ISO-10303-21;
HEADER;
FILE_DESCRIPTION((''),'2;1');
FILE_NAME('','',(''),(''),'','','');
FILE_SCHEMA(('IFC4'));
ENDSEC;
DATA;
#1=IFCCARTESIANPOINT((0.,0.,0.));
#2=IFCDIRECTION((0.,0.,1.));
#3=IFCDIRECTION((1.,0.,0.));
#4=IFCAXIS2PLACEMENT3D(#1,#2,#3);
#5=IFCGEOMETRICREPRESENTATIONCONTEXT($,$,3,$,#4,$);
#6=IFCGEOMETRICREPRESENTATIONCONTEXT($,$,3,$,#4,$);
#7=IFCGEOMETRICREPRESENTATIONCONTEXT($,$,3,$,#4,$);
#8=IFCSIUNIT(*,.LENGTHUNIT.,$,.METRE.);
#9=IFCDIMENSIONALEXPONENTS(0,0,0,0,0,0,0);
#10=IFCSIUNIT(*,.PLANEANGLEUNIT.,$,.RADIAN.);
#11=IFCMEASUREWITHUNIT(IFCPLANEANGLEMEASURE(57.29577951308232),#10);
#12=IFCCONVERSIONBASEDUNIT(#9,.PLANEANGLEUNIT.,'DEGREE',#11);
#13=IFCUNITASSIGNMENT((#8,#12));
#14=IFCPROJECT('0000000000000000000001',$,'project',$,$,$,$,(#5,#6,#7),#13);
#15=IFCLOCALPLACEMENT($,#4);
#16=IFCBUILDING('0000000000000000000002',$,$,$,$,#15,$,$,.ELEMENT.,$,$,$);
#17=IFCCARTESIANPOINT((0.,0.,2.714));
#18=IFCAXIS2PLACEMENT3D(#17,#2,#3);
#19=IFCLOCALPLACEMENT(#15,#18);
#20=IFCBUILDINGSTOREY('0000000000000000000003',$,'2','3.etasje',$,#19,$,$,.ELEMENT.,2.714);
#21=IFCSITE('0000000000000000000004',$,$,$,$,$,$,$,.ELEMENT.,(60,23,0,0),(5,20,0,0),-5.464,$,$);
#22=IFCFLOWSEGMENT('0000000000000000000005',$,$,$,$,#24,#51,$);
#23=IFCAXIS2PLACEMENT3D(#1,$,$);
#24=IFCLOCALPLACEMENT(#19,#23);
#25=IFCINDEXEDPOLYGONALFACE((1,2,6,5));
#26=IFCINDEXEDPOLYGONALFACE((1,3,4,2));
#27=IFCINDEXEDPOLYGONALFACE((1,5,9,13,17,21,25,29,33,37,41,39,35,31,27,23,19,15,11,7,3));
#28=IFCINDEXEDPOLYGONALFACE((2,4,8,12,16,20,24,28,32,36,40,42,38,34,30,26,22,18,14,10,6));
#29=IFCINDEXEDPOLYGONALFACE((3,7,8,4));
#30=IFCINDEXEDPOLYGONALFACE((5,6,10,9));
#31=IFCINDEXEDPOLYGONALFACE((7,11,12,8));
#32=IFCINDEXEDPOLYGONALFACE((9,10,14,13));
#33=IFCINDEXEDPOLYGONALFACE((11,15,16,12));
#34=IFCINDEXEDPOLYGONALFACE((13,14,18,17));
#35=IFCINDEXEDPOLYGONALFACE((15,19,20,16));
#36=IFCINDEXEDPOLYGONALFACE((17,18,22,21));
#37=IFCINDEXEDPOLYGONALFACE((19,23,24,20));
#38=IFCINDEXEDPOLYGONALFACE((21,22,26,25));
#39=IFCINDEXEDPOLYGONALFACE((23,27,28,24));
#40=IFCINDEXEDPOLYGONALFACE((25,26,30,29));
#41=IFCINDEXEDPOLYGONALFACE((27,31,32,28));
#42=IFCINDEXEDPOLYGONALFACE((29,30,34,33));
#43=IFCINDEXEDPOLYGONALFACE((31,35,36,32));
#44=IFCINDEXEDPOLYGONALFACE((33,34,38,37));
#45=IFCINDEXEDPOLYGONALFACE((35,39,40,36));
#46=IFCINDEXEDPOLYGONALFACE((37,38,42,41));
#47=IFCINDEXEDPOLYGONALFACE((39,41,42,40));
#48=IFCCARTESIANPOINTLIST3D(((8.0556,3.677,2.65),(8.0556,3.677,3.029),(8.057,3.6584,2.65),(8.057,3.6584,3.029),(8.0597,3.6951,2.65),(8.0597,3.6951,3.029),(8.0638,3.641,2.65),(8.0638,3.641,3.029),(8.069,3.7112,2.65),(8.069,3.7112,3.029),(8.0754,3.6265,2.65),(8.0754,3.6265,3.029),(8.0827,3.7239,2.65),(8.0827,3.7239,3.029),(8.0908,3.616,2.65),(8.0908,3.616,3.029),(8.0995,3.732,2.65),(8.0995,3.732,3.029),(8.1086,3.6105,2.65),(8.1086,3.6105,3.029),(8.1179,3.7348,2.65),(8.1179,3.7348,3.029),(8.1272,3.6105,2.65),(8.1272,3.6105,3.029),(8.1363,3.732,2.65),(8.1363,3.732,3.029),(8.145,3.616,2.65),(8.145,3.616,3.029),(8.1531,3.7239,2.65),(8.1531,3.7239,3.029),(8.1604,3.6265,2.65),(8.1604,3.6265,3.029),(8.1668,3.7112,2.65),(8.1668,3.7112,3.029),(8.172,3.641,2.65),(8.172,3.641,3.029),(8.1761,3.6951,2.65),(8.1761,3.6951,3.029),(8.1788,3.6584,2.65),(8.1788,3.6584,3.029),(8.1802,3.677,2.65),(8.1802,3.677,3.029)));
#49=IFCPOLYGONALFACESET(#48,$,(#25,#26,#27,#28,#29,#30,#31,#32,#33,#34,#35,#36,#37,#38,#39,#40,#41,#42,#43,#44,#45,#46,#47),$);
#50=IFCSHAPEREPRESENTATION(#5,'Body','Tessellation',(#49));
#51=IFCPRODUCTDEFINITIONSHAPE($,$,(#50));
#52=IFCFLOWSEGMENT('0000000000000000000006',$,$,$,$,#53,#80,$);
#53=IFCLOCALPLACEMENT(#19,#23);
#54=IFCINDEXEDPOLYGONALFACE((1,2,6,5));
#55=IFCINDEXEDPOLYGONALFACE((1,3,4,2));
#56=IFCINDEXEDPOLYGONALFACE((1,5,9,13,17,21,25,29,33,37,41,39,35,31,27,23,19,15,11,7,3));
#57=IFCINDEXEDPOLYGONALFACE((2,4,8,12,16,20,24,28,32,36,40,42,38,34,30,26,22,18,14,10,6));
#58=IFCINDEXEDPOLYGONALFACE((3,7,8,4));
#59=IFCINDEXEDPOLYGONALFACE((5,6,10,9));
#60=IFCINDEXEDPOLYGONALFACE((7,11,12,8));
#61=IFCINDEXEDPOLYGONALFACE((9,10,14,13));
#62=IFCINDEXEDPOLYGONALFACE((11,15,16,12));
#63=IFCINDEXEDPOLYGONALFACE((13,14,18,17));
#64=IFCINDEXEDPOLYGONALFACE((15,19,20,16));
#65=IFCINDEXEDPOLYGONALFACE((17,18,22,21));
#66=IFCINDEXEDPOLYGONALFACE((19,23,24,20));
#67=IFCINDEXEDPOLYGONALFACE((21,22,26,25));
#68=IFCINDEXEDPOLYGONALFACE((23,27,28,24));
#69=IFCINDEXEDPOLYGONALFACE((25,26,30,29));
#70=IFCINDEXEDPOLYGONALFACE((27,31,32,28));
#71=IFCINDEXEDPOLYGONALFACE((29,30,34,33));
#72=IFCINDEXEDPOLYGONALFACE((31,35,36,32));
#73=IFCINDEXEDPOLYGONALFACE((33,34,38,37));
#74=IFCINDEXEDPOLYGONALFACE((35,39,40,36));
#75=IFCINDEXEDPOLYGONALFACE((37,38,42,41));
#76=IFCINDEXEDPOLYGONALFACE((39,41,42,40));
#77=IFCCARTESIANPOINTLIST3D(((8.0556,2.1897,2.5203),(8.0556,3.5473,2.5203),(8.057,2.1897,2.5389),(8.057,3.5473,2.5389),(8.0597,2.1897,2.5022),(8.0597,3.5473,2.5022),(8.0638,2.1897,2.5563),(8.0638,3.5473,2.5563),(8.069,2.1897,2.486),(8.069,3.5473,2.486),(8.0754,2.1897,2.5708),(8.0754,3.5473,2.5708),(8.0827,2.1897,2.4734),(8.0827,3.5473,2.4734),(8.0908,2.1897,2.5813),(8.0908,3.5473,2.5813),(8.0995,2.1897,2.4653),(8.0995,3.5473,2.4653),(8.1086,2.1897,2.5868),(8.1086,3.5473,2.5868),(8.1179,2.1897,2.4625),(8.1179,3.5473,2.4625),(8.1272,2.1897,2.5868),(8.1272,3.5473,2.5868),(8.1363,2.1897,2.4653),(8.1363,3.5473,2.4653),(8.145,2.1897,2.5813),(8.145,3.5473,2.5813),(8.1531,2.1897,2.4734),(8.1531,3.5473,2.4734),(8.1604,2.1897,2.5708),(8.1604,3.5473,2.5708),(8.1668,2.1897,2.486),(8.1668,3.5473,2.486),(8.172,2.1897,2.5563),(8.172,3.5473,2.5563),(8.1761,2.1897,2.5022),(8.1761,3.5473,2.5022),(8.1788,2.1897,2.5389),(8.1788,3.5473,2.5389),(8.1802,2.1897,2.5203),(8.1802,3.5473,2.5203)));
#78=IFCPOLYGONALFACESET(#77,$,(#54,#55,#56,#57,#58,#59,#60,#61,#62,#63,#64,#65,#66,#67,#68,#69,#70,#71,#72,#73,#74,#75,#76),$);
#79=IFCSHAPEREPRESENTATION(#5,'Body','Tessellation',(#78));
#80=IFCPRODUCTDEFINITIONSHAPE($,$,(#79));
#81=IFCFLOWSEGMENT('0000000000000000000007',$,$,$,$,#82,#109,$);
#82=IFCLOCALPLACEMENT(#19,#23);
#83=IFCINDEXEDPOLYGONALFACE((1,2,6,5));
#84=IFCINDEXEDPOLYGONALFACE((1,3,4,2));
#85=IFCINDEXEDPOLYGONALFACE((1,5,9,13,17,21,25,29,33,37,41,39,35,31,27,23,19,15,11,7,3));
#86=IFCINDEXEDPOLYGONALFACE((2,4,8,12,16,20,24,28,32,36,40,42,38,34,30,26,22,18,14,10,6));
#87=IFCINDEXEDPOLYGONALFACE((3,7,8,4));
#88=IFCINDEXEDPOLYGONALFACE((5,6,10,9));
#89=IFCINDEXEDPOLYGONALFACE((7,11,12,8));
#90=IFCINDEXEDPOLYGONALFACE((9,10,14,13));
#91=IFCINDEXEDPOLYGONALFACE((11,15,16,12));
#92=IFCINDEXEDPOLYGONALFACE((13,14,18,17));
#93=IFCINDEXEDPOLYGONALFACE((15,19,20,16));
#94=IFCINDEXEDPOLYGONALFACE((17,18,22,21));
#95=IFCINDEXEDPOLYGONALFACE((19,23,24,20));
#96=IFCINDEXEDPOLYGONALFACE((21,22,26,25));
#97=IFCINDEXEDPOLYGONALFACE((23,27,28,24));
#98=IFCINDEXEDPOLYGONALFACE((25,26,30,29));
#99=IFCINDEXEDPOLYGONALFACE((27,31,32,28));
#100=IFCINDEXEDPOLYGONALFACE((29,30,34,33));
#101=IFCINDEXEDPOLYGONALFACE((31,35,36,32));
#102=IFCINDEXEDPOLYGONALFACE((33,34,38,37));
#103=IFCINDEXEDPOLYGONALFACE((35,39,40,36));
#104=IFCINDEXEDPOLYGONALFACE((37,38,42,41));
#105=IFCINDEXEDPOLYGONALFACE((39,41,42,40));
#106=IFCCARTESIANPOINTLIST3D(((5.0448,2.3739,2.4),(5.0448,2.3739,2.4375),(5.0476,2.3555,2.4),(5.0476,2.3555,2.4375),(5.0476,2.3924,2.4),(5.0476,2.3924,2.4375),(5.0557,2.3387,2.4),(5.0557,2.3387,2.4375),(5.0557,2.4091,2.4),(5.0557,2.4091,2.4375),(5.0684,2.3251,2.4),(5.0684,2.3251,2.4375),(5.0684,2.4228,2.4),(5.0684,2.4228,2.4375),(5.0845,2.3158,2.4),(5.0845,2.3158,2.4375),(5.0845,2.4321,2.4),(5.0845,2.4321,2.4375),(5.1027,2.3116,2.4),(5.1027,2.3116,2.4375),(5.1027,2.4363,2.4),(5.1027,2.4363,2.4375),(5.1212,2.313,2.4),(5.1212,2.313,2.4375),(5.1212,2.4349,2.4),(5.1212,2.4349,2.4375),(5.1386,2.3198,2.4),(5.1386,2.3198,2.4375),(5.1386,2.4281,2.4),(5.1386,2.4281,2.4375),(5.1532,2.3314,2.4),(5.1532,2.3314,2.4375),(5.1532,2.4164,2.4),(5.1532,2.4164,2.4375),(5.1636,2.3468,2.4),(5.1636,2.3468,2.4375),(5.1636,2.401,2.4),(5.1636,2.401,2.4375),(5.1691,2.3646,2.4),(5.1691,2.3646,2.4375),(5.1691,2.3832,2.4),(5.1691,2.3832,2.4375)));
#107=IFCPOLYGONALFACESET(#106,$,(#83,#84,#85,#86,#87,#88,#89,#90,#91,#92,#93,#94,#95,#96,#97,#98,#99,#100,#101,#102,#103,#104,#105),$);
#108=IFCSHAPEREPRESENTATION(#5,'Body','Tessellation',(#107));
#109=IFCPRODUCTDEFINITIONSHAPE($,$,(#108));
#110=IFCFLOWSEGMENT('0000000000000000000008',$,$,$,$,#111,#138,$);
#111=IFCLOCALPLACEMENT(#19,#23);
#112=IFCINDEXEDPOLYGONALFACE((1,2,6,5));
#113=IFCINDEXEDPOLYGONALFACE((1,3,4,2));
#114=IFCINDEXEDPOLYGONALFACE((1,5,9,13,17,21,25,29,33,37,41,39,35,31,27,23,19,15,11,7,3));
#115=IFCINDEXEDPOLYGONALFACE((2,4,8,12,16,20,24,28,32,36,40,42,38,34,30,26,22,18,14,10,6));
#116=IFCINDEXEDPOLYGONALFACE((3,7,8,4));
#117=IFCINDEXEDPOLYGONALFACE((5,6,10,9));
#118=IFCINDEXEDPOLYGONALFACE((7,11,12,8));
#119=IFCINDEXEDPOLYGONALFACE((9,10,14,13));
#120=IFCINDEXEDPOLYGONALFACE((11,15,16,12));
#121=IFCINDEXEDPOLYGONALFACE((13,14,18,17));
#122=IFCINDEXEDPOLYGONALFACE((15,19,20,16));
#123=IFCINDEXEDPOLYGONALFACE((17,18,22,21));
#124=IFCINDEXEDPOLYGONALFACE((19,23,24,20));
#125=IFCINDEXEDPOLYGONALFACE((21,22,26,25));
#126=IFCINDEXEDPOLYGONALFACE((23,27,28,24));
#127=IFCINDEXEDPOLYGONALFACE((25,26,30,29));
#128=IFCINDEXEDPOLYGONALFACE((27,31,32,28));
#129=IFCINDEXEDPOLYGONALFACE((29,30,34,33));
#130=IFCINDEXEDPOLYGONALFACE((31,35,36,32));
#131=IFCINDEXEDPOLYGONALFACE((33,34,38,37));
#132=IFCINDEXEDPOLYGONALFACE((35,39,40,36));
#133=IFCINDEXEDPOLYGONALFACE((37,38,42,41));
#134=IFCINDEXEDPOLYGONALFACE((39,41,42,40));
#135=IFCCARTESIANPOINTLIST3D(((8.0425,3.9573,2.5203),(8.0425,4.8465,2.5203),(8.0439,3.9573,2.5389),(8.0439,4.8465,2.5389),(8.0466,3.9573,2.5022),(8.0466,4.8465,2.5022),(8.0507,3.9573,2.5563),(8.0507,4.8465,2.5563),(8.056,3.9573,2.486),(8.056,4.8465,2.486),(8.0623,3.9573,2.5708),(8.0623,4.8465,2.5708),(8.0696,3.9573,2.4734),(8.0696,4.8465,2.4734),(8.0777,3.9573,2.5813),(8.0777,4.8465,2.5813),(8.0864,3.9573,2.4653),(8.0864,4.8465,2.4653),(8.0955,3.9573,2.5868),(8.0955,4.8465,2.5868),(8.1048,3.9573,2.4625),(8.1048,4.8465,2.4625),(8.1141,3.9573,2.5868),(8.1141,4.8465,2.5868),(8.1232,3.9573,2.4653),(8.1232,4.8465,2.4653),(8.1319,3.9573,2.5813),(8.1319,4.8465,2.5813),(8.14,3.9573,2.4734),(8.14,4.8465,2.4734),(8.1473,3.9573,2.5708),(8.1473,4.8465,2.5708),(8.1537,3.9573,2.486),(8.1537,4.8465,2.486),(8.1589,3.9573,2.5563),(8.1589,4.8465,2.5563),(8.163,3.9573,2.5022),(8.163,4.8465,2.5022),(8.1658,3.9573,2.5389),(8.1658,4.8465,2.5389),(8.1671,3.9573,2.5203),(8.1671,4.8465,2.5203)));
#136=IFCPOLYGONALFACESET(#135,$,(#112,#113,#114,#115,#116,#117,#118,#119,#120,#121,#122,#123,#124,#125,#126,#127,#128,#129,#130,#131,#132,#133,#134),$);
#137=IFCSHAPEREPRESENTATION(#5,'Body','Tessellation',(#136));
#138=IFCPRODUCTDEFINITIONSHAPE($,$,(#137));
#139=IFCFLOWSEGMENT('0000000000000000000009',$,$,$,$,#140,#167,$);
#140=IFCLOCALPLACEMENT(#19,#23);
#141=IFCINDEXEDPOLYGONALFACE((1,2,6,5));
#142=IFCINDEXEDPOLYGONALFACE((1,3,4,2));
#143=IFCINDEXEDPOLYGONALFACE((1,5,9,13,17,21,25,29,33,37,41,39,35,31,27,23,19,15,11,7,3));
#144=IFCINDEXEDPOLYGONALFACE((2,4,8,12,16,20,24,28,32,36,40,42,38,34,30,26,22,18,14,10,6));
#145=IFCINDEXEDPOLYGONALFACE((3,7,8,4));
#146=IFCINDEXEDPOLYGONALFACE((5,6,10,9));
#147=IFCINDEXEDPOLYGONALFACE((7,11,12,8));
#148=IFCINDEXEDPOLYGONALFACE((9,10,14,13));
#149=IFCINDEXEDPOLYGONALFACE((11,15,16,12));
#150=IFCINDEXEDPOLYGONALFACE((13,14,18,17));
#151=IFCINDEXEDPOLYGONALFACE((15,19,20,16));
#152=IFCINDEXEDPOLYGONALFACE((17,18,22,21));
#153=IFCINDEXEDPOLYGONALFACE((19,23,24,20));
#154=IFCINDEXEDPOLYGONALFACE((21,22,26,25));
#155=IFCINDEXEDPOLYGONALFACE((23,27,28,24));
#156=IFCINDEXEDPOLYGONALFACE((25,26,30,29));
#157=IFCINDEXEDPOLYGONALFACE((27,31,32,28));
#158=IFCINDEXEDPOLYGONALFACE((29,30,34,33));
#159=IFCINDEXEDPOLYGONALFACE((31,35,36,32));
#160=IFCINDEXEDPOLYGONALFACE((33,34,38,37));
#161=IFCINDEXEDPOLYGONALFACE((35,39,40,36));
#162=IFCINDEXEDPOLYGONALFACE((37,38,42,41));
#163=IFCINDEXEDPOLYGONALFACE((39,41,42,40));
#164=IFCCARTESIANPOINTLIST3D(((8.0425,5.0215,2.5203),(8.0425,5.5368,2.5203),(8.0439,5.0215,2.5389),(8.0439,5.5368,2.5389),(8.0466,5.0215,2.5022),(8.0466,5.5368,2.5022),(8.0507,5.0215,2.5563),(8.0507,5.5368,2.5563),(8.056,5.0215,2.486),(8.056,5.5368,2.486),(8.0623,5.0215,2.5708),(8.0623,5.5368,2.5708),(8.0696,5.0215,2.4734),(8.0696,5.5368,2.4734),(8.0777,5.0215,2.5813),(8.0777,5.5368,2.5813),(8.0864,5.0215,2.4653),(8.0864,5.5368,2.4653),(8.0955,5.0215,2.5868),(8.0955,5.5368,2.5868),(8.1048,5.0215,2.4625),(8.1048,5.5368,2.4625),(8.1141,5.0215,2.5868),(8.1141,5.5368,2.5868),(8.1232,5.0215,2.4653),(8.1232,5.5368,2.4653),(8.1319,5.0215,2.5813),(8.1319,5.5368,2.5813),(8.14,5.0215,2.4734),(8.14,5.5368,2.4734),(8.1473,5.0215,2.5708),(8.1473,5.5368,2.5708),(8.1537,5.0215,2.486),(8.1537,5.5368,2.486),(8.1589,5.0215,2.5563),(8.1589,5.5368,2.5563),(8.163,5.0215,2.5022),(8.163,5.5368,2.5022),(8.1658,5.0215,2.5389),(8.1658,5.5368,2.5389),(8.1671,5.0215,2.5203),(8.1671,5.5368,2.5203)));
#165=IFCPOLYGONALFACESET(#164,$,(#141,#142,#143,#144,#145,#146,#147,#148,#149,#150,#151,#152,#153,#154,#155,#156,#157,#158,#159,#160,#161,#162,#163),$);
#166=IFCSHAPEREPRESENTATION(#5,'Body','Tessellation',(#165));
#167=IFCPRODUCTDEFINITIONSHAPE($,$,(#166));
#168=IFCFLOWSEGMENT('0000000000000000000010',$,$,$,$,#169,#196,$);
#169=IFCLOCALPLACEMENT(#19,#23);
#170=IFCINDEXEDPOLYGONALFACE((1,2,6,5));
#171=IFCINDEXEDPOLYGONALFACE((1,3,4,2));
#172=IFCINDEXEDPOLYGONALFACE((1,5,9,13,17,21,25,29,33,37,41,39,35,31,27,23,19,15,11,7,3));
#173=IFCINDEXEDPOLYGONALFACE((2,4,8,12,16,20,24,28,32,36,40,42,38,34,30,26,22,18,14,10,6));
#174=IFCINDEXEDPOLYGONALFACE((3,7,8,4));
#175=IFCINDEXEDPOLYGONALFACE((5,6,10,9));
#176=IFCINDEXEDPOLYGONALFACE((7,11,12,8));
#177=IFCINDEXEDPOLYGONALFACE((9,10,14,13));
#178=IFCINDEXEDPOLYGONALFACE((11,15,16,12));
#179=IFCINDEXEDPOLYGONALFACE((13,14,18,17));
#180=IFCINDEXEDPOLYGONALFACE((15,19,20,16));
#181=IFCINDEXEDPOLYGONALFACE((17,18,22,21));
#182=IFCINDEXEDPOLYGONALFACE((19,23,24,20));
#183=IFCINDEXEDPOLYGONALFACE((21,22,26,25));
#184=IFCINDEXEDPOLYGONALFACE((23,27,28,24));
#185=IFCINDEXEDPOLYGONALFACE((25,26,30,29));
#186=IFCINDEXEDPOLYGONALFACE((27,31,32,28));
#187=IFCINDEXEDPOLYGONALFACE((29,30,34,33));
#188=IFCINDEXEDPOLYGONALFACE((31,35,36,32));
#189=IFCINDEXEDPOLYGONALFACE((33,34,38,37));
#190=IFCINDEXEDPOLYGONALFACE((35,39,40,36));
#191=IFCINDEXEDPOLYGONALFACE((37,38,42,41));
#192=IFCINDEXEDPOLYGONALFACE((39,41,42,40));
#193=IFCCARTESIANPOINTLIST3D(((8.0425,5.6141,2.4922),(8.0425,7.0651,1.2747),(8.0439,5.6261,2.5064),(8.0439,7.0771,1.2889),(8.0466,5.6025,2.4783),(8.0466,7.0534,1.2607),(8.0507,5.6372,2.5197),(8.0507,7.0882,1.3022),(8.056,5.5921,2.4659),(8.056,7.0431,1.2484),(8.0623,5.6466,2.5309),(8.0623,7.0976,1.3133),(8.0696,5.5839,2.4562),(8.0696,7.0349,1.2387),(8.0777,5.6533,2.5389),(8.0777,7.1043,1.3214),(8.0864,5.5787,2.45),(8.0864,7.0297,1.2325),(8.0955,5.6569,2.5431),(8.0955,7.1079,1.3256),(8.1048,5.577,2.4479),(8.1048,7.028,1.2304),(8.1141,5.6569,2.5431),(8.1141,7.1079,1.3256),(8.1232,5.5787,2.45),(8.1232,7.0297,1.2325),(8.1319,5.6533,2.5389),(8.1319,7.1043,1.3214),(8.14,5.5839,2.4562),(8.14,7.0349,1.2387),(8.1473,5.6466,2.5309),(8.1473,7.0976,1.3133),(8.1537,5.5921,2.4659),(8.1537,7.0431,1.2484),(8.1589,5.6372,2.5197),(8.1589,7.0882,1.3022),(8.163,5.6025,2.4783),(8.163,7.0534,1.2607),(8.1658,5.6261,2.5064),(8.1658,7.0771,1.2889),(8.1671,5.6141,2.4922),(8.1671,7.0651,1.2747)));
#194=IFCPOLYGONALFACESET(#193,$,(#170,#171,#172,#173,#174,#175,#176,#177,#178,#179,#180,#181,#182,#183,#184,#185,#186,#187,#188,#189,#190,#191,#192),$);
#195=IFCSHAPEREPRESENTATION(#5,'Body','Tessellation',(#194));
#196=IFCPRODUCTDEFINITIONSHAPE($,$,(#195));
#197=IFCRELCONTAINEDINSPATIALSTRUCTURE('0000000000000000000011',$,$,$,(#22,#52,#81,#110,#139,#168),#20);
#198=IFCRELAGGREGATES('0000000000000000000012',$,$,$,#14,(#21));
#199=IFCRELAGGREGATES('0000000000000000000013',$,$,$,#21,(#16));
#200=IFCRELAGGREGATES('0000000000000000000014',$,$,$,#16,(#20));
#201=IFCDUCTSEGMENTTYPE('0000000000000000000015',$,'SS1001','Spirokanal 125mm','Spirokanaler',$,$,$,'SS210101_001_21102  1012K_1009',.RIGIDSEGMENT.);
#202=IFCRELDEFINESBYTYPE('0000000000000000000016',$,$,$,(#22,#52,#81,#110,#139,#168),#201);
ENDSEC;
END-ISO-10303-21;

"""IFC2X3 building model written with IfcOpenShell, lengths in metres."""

from ifc_helpers import new_model, entity, si_unit, converted_unit, frame, origin_with_axes, origin_2d_with_axis, place, context, project, spatial, circle, extrude, type_object, element, save


model = new_model("IFC2X3")

# Units and contexts
context_of_model_1 = context(None, 3, world=origin_with_axes())
context_of_model_2 = context(None, 3, world=origin_with_axes())
context_of_model_3 = context(None, 3, world=origin_with_axes())
ifc_project = project(units=[si_unit("LENGTHUNIT", "METRE"), converted_unit("PLANEANGLEUNIT", "DEGREE", entity("IfcPlaneAngleMeasure", 57.29577951308232), si_unit("PLANEANGLEUNIT", "RADIAN"), dimensions=[0, 0, 0, 0, 0, 0, 0])], contexts=[context_of_model_1, context_of_model_2, context_of_model_3])

# Site, building, storey
site = spatial("IfcSite", under=ifc_project, CompositionType="ELEMENT", RefLatitude=(60, 23, 0, 0), RefLongitude=(5, 20, 0, 0), RefElevation=-5.464)
building_placement = place(None, origin_with_axes())
building = spatial("IfcBuilding", under=site, at=building_placement, CompositionType="ELEMENT")
storey_placement = place(building_placement, frame((0.0, 0.0, 2.714), z_axis=(0.0, 0.0, 1.0), x_axis=(1.0, 0.0, 0.0)))
storey = spatial("IfcBuildingStorey", under=building, at=storey_placement, Name="2", Description="3.etasje", CompositionType="ELEMENT", Elevation=2.714)

# Flow segments
duct_segment_type_1 = type_object("IfcDuctSegmentType", Name="SS1001", Description="Spirokanal 125mm", ApplicableOccurrence="Spirokanaler", ElementType="SS210101_001_21102  1012K_1009", PredefinedType="RIGIDSEGMENT")
flow_segment_1_placement = place(storey_placement, frame((8.1179, 3.6723, 3.029), z_axis=(0.0, 0.0, -1.0), x_axis=(0.0, 1.0, 0.0)))
element("IfcFlowSegment", 1, at=flow_segment_1_placement, inside=storey, type_object=duct_segment_type_1, context=context_of_model_1, shape_type="SweptSolid", body=[
    extrude(circle(Radius=0.0625, at=origin_2d_with_axis()), origin_with_axes(), (0.0, 0.0, 1.0), 0.379),
])
flow_segment_2_placement = place(storey_placement, frame((8.1179, 3.5473, 2.525), z_axis=(0.0, -1.0, 0.0), x_axis=(0.0, 0.0, -1.0)))
element("IfcFlowSegment", 2, at=flow_segment_2_placement, inside=storey, type_object=duct_segment_type_1, context=context_of_model_1, shape_type="SweptSolid", body=[
    extrude(circle(Radius=0.0625, at=origin_2d_with_axis()), origin_with_axes(), (0.0, 0.0, 1.0), 1.3575),
])
flow_segment_3_placement = place(storey_placement, frame((5.1073, 2.3739, 2.4375), z_axis=(0.0, 0.0, -1.0), x_axis=(-1.0, 0.0, 0.0)))
element("IfcFlowSegment", 3, at=flow_segment_3_placement, inside=storey, type_object=duct_segment_type_1, context=context_of_model_1, shape_type="SweptSolid", body=[
    extrude(circle(Radius=0.0625, at=origin_2d_with_axis()), origin_with_axes(), (0.0, 0.0, 1.0), 0.0375),
])
flow_segment_4_placement = place(storey_placement, frame((8.1048, 3.9573, 2.525), z_axis=(0.0, 1.0, 0.0), x_axis=(0.0, 0.0, -1.0)))
element("IfcFlowSegment", 4, at=flow_segment_4_placement, inside=storey, type_object=duct_segment_type_1, context=context_of_model_1, shape_type="SweptSolid", body=[
    extrude(circle(Radius=0.0625, at=origin_2d_with_axis()), origin_with_axes(), (0.0, 0.0, 1.0), 0.8892),
])
flow_segment_5_placement = place(storey_placement, frame((8.1048, 5.0215, 2.525), z_axis=(0.0, 1.0, 0.0), x_axis=(0.0, 0.0, -1.0)))
element("IfcFlowSegment", 5, at=flow_segment_5_placement, inside=storey, type_object=duct_segment_type_1, context=context_of_model_1, shape_type="SweptSolid", body=[
    extrude(circle(Radius=0.0625, at=origin_2d_with_axis()), origin_with_axes(), (0.0, 0.0, 1.0), 0.5153),
])
flow_segment_6_placement = place(storey_placement, frame((8.1048, 5.6171, 2.4958), z_axis=(0.0, 0.766044, -0.642788), x_axis=(0.0, -0.642788, -0.766044)))
element("IfcFlowSegment", 6, at=flow_segment_6_placement, inside=storey, type_object=duct_segment_type_1, context=context_of_model_1, shape_type="SweptSolid", body=[
    extrude(circle(Radius=0.0625, at=origin_2d_with_axis()), origin_with_axes(), (0.0, 0.0, 1.0), 1.8941),
])

save(model, "model.ifc")
